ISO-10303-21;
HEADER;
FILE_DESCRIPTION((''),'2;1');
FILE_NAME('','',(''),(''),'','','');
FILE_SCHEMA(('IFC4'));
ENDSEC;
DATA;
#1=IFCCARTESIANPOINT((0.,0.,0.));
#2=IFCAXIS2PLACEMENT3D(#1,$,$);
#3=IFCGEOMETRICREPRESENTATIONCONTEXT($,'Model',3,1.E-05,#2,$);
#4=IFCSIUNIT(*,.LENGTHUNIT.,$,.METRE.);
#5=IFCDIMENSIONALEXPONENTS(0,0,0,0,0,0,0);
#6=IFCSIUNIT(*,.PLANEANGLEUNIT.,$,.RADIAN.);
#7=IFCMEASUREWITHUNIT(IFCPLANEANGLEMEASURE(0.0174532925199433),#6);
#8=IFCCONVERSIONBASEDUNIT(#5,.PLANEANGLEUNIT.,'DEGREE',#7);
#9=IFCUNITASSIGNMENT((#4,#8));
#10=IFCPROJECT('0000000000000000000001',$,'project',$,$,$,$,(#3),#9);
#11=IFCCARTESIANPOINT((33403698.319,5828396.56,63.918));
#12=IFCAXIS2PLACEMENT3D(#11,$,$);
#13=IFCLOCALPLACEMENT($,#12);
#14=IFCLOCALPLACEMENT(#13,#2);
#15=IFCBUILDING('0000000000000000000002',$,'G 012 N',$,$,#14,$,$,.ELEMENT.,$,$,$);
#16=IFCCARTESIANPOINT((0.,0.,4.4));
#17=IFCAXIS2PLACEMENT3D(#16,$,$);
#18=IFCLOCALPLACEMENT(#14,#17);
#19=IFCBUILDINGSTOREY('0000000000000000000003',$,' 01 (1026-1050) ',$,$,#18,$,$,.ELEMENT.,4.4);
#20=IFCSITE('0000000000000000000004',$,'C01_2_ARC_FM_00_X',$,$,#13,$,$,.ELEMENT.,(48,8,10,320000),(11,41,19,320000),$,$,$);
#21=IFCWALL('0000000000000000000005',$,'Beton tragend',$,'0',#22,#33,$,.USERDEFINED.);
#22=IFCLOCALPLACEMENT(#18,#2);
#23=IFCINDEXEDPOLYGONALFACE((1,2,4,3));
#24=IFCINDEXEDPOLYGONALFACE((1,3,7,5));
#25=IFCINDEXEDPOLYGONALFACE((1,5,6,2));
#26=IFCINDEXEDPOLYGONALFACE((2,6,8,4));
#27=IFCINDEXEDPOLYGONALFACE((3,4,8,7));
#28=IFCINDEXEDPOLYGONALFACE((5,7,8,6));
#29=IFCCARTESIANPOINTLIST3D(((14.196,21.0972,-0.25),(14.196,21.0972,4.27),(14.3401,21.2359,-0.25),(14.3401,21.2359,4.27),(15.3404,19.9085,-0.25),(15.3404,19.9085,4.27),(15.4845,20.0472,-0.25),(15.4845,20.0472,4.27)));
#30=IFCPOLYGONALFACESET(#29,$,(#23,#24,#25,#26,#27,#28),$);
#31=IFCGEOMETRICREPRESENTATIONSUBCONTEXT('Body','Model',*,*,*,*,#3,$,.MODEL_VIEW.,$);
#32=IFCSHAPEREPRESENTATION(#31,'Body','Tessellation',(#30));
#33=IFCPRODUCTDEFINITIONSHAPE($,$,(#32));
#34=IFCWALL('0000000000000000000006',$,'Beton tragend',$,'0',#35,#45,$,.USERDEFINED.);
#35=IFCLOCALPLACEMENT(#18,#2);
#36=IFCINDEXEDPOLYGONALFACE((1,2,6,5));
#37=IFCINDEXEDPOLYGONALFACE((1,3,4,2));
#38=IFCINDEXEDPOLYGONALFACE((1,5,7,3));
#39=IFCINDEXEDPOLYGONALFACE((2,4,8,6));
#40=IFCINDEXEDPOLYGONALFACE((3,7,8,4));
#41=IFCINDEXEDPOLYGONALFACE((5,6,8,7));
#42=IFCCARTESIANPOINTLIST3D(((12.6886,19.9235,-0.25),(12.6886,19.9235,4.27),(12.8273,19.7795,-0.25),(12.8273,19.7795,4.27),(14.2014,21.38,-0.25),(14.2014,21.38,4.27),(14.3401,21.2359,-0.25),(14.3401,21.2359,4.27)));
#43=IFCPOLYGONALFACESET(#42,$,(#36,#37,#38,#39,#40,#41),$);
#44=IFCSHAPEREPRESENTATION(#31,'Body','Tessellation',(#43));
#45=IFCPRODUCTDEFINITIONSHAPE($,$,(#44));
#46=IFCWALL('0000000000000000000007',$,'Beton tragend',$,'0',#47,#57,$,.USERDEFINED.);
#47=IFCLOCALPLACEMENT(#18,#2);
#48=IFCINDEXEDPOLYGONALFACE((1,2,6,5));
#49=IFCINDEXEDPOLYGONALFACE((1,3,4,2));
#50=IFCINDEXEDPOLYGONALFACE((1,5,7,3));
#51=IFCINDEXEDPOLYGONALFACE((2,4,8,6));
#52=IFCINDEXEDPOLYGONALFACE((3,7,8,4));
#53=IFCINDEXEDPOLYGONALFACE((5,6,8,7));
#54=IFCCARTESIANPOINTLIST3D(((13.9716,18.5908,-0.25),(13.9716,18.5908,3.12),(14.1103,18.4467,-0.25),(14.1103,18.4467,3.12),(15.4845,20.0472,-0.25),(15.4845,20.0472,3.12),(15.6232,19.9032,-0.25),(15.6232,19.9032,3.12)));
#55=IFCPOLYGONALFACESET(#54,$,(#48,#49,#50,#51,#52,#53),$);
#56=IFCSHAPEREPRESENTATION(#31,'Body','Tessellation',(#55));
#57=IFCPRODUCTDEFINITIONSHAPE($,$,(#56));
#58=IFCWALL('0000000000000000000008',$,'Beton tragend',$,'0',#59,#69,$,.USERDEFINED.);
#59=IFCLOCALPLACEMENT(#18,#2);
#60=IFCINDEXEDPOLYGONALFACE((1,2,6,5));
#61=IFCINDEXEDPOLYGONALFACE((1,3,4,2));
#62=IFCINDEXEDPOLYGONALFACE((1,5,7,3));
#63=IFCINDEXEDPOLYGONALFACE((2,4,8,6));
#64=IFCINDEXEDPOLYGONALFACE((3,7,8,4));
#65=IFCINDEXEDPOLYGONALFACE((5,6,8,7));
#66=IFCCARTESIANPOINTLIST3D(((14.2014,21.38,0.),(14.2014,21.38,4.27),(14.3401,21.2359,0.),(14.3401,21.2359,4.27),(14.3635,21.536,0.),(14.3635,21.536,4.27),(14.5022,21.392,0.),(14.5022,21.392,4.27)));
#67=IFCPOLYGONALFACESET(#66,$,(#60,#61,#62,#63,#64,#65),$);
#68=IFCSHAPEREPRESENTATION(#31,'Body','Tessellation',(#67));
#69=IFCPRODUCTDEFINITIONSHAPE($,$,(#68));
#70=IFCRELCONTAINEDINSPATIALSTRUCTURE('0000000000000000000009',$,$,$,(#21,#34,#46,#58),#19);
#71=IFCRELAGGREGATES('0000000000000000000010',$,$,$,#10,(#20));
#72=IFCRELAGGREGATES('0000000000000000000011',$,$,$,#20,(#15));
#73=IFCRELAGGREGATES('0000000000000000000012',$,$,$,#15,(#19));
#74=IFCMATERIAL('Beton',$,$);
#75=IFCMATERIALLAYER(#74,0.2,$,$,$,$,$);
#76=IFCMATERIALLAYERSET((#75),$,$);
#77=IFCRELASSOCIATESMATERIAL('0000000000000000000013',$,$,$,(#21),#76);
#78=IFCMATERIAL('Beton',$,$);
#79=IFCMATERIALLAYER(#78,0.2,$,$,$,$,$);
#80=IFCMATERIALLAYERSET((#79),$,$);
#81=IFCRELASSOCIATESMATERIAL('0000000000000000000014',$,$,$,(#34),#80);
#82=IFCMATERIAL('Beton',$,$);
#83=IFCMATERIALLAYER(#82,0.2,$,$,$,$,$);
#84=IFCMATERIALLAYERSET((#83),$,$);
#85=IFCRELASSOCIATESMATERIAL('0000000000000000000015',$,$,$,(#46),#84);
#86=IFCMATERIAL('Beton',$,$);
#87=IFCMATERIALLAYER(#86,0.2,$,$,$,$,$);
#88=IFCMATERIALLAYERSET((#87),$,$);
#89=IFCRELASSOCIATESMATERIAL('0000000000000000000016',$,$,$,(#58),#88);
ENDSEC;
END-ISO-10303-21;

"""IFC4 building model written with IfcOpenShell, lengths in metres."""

from ifc_helpers import new_model, entity, si_unit, converted_unit, frame, frame_2d, origin, origin_with_axes, place, context, subcontext, project, spatial, rectangle, extrude, material, layer, layer_set, layer_usage, element, save


model = new_model("IFC4")

# Units and contexts
model_context = context("Model", 3, precision=1e-05, world=origin())
body_context = subcontext(model_context, "Body", "Model", "MODEL_VIEW")
ifc_project = project(units=[si_unit("LENGTHUNIT", "METRE"), converted_unit("PLANEANGLEUNIT", "DEGREE", entity("IfcPlaneAngleMeasure", 0.0174532925199433), si_unit("PLANEANGLEUNIT", "RADIAN"), dimensions=[0, 0, 0, 0, 0, 0, 0])], contexts=[model_context])

# Site, building, storey
site_placement = place(None, frame((33403698.319, 5828396.56, 63.918)))
site = spatial("IfcSite", under=ifc_project, at=site_placement, Name="C01_2_ARC_FM_00_X", CompositionType="ELEMENT", RefLatitude=(48, 8, 10, 320000), RefLongitude=(11, 41, 19, 320000))
building_placement = place(site_placement, origin())
building = spatial("IfcBuilding", under=site, at=building_placement, Name="G 012 N", CompositionType="ELEMENT")
storey_placement = place(building_placement, frame((0.0, 0.0, 4.4)))
storey = spatial("IfcBuildingStorey", under=building, at=storey_placement, Name=" 01 (1026-1050) ", CompositionType="ELEMENT", Elevation=4.4)

# Walls
ifc_material_1 = material(Name="Beton")
ifc_layer_1 = layer(ifc_material_1, 0.2)
ifc_layer_set_1 = layer_set([ifc_layer_1])
ifc_layer_usage_1 = layer_usage(ifc_layer_set_1, "AXIS2", "POSITIVE", 0.0)
wall_1_placement = place(storey_placement, frame((15.4845, 20.0472, -0.25), z_axis=(0.0, 0.0, 1.0), x_axis=(-0.693551, 0.720408, 0.0)))
element("IfcWall", 1, at=wall_1_placement, inside=storey, material=ifc_layer_usage_1, Name="Beton tragend", ObjectType="0", PredefinedType="USERDEFINED", context=body_context, shape_type="SweptSolid", body=[
    extrude(rectangle(XDim=1.65, YDim=0.2, at=frame_2d((0.825, 0.1), x_axis=(1.0, 0.0))), origin_with_axes(), (0.0, 0.0, 1.0), 4.52),
])
ifc_material_2 = material(Name="Beton")
ifc_layer_2 = layer(ifc_material_2, 0.2)
ifc_layer_set_2 = layer_set([ifc_layer_2])
ifc_layer_usage_2 = layer_usage(ifc_layer_set_2, "AXIS2", "POSITIVE", 0.0)
wall_2_placement = place(storey_placement, frame((14.2014, 21.38, -0.25), z_axis=(0.0, 0.0, 1.0), x_axis=(-0.720408, -0.693551, 0.0)))
element("IfcWall", 2, at=wall_2_placement, inside=storey, material=ifc_layer_usage_2, Name="Beton tragend", ObjectType="0", PredefinedType="USERDEFINED", context=body_context, shape_type="SweptSolid", body=[
    extrude(rectangle(XDim=2.1, YDim=0.2, at=frame_2d((1.05, 0.1), x_axis=(1.0, 0.0))), origin_with_axes(), (0.0, 0.0, 1.0), 4.52),
])
ifc_material_3 = material(Name="Beton")
ifc_layer_3 = layer(ifc_material_3, 0.2)
ifc_layer_set_3 = layer_set([ifc_layer_3])
ifc_layer_usage_3 = layer_usage(ifc_layer_set_3, "AXIS2", "POSITIVE", 0.0)
wall_3_placement = place(storey_placement, frame((15.4845, 20.0472, -0.25), z_axis=(0.0, 0.0, 1.0), x_axis=(-0.720408, -0.693551, 0.0)))
element("IfcWall", 3, at=wall_3_placement, inside=storey, material=ifc_layer_usage_3, Name="Beton tragend", ObjectType="0", PredefinedType="USERDEFINED", context=body_context, shape_type="SweptSolid", body=[
    extrude(rectangle(XDim=2.1, YDim=0.2, at=frame_2d((1.05, 0.1), x_axis=(1.0, 0.0))), origin_with_axes(), (0.0, 0.0, 1.0), 3.37),
])
ifc_material_4 = material(Name="Beton")
ifc_layer_4 = layer(ifc_material_4, 0.2)
ifc_layer_set_4 = layer_set([ifc_layer_4])
ifc_layer_usage_4 = layer_usage(ifc_layer_set_4, "AXIS2", "POSITIVE", 0.0)
wall_4_placement = place(storey_placement, frame((14.3401, 21.2359, 0.0), z_axis=(0.0, 0.0, 1.0), x_axis=(0.720408, 0.693551, 0.0)))
element("IfcWall", 4, at=wall_4_placement, inside=storey, material=ifc_layer_usage_4, Name="Beton tragend", ObjectType="0", PredefinedType="USERDEFINED", context=body_context, shape_type="SweptSolid", body=[
    extrude(rectangle(XDim=0.225, YDim=0.2, at=frame_2d((0.1125, 0.1), x_axis=(1.0, 0.0))), origin_with_axes(), (0.0, 0.0, 1.0), 4.27),
])

save(model, "model.ifc")
